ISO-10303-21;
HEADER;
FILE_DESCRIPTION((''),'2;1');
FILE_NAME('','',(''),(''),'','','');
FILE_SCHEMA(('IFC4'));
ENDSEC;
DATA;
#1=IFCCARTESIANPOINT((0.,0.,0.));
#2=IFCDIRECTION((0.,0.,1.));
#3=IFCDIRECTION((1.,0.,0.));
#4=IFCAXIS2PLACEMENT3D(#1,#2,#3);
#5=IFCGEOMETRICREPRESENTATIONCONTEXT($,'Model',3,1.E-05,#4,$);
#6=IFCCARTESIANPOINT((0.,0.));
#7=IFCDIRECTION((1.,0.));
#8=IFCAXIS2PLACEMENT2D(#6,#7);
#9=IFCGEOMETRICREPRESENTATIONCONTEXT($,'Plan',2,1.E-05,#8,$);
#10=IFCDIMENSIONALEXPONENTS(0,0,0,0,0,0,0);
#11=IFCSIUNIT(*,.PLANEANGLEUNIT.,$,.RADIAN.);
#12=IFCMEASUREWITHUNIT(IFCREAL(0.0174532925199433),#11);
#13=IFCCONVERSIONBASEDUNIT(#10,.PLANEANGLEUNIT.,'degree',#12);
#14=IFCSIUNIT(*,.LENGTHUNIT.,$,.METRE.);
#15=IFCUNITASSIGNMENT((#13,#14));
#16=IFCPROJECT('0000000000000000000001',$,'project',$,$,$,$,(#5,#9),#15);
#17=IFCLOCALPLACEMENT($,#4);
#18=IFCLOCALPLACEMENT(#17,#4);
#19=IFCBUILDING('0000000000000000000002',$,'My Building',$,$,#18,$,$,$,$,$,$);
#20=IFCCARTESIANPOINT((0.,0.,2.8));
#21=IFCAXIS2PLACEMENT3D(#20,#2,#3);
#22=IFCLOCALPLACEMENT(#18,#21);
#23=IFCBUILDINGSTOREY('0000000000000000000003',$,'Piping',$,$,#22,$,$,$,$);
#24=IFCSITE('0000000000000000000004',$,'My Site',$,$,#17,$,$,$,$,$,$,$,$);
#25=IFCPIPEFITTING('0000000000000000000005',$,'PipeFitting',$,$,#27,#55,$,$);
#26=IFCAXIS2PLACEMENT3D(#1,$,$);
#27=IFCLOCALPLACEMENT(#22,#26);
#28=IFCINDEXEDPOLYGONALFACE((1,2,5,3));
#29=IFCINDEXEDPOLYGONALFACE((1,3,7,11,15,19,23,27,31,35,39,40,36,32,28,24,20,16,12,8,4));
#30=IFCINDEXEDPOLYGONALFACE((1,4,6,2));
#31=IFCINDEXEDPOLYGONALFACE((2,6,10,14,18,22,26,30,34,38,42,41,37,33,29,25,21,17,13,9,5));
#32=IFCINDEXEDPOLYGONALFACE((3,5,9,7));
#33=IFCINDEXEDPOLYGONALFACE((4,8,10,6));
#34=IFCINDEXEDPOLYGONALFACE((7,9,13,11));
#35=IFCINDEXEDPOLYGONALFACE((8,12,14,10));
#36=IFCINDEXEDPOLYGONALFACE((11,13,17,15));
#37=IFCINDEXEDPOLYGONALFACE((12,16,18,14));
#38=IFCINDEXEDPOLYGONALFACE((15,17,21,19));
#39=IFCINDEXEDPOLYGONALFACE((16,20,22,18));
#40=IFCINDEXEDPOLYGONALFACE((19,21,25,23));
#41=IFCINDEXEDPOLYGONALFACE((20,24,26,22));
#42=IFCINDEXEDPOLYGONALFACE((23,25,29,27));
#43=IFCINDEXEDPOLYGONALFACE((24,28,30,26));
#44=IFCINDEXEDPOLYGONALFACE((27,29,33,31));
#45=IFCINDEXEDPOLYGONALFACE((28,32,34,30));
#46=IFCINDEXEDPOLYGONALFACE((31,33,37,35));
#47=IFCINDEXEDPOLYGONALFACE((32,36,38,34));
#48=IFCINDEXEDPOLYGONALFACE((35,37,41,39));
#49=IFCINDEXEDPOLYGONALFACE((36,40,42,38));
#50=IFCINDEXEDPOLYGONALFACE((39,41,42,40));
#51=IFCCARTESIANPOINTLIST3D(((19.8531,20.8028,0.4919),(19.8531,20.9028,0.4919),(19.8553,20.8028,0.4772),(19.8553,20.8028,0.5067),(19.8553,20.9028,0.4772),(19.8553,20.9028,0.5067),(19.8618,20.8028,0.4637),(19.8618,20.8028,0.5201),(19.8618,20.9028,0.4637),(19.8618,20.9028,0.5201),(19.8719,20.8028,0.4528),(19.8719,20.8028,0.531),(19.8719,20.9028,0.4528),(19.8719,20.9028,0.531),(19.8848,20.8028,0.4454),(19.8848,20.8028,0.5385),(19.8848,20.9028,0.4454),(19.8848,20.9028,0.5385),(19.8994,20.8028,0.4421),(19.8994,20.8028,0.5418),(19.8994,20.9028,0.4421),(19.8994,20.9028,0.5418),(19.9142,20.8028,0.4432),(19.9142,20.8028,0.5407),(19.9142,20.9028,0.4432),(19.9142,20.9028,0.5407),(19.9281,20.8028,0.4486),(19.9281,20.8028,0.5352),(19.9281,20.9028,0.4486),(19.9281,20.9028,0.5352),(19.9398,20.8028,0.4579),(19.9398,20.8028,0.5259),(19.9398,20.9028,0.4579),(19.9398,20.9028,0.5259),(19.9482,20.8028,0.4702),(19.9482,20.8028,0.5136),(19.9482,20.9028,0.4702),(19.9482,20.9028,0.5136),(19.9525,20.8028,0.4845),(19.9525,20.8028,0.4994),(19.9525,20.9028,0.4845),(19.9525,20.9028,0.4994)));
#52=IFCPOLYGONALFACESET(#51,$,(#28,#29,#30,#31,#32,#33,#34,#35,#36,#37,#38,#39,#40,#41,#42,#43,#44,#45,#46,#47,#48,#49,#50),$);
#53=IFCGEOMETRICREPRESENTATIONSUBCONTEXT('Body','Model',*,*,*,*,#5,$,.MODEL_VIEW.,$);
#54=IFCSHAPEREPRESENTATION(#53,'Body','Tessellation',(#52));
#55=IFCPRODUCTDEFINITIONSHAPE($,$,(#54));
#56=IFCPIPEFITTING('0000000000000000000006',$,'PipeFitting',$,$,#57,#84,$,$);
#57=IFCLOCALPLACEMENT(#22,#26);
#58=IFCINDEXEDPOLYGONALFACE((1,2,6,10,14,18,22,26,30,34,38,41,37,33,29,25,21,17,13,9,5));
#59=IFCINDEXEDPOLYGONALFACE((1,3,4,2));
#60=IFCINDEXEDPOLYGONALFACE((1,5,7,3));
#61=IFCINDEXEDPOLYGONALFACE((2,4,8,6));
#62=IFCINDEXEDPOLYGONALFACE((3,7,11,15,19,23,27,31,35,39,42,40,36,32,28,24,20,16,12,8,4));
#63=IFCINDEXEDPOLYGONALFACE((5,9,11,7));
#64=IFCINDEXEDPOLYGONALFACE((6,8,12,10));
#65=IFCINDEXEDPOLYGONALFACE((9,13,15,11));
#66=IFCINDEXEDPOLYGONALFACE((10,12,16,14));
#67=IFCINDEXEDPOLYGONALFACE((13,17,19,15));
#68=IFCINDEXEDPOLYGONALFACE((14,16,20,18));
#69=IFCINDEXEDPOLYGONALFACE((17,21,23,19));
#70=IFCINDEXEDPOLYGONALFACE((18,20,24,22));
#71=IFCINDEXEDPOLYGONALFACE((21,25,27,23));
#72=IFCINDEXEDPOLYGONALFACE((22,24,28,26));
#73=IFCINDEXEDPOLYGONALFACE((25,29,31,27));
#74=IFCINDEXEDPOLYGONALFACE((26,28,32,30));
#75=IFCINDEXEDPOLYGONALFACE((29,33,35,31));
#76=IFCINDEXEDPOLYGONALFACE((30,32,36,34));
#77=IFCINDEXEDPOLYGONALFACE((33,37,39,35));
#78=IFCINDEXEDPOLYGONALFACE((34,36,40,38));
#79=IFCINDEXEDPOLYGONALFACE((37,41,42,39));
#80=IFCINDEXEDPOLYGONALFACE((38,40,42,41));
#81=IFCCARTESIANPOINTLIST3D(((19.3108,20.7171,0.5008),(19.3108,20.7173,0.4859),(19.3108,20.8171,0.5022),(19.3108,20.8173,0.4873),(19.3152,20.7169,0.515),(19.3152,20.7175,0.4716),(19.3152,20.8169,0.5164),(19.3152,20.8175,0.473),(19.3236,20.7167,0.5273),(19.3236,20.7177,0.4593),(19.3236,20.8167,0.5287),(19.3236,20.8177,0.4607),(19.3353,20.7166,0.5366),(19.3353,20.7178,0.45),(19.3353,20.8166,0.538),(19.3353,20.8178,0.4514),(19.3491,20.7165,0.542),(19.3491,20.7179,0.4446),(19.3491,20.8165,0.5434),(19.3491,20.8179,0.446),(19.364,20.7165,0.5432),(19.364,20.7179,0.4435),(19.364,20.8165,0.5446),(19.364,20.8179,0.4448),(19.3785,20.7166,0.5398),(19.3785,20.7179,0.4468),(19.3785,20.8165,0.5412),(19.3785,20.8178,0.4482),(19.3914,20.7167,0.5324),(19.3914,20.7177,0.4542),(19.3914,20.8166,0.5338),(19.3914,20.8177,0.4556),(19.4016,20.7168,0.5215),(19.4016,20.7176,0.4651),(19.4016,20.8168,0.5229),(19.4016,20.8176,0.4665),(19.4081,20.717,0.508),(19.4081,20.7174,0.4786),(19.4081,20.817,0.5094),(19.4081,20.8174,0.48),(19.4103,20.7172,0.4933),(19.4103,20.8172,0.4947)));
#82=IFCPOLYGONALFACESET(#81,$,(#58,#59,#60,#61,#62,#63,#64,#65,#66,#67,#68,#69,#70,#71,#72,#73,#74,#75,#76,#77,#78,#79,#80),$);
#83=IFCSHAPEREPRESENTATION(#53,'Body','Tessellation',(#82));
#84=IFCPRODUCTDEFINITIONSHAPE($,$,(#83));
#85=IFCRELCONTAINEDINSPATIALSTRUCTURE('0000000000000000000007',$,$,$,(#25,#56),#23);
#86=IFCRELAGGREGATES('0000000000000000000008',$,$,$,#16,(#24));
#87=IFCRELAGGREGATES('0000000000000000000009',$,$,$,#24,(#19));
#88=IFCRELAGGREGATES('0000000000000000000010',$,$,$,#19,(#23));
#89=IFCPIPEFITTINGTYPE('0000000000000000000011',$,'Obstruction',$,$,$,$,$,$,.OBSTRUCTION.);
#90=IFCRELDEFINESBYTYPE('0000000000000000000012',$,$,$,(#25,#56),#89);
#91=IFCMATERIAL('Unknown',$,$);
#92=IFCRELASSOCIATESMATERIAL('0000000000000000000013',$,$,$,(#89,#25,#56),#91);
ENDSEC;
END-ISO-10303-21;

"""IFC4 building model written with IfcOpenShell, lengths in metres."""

from ifc_helpers import new_model, entity, si_unit, converted_unit, frame, origin_with_axes, origin_2d_with_axis, place, context, subcontext, project, spatial, circle, extrude, material, material_profile, profile_set, profile_usage, type_object, element, save


model = new_model("IFC4")

# Units and contexts
model_context = context("Model", 3, precision=1e-05, world=origin_with_axes())
plan_context = context("Plan", 2, precision=1e-05, world=origin_2d_with_axis())
body_context = subcontext(model_context, "Body", "Model", "MODEL_VIEW")
ifc_project = project(units=[converted_unit("PLANEANGLEUNIT", "degree", entity("IfcReal", 0.0174532925199433), si_unit("PLANEANGLEUNIT", "RADIAN"), dimensions=[0, 0, 0, 0, 0, 0, 0]), si_unit("LENGTHUNIT", "METRE")], contexts=[model_context, plan_context])

# Site, building, storey
site_placement = place(None, origin_with_axes())
site = spatial("IfcSite", under=ifc_project, at=site_placement, Name="My Site")
building_placement = place(site_placement, origin_with_axes())
building = spatial("IfcBuilding", under=site, at=building_placement, Name="My Building")
storey_placement = place(building_placement, frame((0.0, 0.0, 2.8), z_axis=(0.0, 0.0, 1.0), x_axis=(1.0, 0.0, 0.0)))
storey = spatial("IfcBuildingStorey", under=building, at=storey_placement, Name="Piping")

# Shared definitions
ifc_material = material(Name="Unknown")

# Pipe fittings
ifc_material_profile_1 = material_profile(ifc_material, circle(Radius=0.05))
ifc_profile_set_1 = profile_set([ifc_material_profile_1])
pipe_fitting_type_1 = type_object("IfcPipeFittingType", Name="Obstruction", PredefinedType="OBSTRUCTION", material=ifc_profile_set_1)
ifc_profile_usage_1 = profile_usage(ifc_profile_set_1, cardinal=5)
pipe_fitting_1_placement = place(storey_placement, frame((19.9031, 20.8028, 0.4919), z_axis=(0.0, 1.0, 0.0), x_axis=(-1.0, 0.0, 0.0)))
element("IfcPipeFitting", 1, at=pipe_fitting_1_placement, inside=storey, type_object=pipe_fitting_type_1, material=ifc_profile_usage_1, Name="PipeFitting", context=body_context, shape_type="SweptSolid", body=[
    extrude(circle(Radius=0.05), origin_with_axes(), (0.0, 0.0, 1.0), 0.1),
])
ifc_profile_usage_2 = profile_usage(ifc_profile_set_1, cardinal=5)
pipe_fitting_2_placement = place(storey_placement, frame((19.3603, 20.8172, 0.4947), z_axis=(0.0, -0.999903, -0.013947), x_axis=(1.0, 0.0, 0.0)))
element("IfcPipeFitting", 2, at=pipe_fitting_2_placement, inside=storey, type_object=pipe_fitting_type_1, material=ifc_profile_usage_2, Name="PipeFitting", context=body_context, shape_type="SweptSolid", body=[
    extrude(circle(Radius=0.05), origin_with_axes(), (0.0, 0.0, 1.0), 0.1),
])

save(model, "model.ifc")
